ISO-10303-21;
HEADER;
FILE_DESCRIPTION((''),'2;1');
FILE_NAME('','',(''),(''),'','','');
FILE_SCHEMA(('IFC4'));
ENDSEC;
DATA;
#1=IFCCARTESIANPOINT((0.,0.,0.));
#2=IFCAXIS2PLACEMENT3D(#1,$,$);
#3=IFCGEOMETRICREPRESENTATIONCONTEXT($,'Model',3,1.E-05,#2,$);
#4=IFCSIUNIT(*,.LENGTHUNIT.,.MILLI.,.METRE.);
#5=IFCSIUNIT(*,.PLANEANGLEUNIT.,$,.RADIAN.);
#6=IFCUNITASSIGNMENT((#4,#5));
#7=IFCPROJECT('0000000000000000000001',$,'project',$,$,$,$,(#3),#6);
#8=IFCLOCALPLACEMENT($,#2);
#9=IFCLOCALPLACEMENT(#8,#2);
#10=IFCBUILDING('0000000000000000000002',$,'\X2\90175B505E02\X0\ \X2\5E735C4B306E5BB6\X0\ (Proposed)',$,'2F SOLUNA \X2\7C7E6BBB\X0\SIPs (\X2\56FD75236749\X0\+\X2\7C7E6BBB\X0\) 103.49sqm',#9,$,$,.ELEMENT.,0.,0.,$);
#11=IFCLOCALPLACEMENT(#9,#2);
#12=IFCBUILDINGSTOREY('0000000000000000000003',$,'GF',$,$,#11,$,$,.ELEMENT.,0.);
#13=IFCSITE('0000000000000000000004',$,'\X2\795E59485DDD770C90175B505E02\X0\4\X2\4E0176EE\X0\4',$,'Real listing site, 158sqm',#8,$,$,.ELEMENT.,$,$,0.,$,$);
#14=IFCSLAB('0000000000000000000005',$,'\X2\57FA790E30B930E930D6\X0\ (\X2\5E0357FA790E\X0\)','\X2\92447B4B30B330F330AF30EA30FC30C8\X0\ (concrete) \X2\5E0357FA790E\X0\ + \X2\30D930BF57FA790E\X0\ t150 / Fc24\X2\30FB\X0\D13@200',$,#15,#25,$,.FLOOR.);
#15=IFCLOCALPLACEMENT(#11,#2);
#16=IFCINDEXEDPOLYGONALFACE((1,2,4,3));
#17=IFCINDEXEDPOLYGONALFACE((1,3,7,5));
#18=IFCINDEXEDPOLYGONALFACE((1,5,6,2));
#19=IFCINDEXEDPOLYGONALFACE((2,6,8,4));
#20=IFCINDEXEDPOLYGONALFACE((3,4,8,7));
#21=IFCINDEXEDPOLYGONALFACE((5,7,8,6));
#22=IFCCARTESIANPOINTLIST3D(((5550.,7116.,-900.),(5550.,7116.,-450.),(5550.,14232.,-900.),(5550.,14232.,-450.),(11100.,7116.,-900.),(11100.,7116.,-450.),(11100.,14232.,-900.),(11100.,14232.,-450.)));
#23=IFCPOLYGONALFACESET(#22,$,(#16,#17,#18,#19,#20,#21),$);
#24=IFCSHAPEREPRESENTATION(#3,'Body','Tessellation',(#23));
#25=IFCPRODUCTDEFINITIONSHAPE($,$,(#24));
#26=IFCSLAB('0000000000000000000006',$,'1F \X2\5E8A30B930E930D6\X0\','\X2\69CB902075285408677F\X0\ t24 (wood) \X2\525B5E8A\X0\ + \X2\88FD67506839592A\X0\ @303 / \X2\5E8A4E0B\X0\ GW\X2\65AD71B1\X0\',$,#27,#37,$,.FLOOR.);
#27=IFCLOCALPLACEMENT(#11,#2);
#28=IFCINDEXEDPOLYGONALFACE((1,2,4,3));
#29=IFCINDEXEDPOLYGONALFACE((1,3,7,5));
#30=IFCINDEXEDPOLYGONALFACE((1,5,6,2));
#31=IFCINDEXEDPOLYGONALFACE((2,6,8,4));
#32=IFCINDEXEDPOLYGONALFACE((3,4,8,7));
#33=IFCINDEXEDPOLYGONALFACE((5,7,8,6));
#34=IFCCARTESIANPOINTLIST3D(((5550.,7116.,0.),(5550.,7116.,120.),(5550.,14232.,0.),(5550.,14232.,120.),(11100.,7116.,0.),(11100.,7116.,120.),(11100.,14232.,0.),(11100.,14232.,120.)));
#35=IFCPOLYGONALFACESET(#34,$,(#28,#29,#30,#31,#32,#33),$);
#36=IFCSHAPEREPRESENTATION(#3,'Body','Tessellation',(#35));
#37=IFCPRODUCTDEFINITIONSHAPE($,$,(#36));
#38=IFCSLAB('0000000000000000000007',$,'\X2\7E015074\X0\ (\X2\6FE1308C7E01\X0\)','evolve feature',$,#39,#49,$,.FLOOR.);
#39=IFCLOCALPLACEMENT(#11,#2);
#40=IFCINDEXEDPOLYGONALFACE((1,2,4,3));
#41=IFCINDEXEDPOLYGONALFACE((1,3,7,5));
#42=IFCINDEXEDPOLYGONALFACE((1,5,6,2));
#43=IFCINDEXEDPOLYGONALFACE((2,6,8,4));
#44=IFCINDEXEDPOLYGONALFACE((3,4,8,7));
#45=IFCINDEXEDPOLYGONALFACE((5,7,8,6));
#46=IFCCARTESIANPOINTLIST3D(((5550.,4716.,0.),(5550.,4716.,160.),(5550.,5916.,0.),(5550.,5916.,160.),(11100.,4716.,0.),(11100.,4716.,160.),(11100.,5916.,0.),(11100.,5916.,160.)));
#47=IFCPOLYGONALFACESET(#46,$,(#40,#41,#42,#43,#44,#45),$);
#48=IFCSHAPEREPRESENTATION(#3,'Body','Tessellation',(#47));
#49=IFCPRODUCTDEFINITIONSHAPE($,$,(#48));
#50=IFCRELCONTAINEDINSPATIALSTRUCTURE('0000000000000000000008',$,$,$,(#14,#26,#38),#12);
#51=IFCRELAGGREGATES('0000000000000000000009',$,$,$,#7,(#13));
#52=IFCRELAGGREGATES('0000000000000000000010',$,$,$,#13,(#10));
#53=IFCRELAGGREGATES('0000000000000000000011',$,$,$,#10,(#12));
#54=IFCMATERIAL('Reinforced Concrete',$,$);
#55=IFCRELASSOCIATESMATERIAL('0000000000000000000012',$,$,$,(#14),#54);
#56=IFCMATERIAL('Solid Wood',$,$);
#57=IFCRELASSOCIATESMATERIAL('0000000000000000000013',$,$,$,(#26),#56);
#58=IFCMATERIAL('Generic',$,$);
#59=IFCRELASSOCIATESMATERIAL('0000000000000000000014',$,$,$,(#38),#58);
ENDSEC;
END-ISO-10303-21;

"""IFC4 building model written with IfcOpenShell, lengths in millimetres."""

from ifc_helpers import new_model, si_unit, frame, frame_2d, origin, place, context, project, spatial, rectangle, extrude, material, element, save


model = new_model("IFC4")

# Units and contexts
model_context = context("Model", 3, precision=1e-05, world=origin())
ifc_project = project(units=[si_unit("LENGTHUNIT", "METRE", prefix="MILLI"), si_unit("PLANEANGLEUNIT", "RADIAN")], contexts=[model_context])

# Site, building, storey
site_placement = place(None, origin())
site = spatial("IfcSite", under=ifc_project, at=site_placement, Name="神奈川県逗子市4丁目4", ObjectType="Real listing site, 158sqm", CompositionType="ELEMENT", RefElevation=0.0)
building_placement = place(site_placement, origin())
building = spatial("IfcBuilding", under=site, at=building_placement, Name="逗子市 平屋の家 (Proposed)", ObjectType="2F SOLUNA 籾殻SIPs (国産杉+籾殻) 103.49sqm", CompositionType="ELEMENT", ElevationOfRefHeight=0.0, ElevationOfTerrain=0.0)
storey_placement = place(building_placement, origin())
storey = spatial("IfcBuildingStorey", under=building, at=storey_placement, Name="GF", CompositionType="ELEMENT", Elevation=0.0)

# Slabs
ifc_material_1 = material(Name="Reinforced Concrete")
slab_1_placement = place(storey_placement, frame((2775.0, 3558.0, -450.0)))
element("IfcSlab", 1, at=slab_1_placement, inside=storey, material=ifc_material_1, Name="基礎スラブ (布基礎)", Description="鉄筋コンクリート (concrete) 布基礎 + ベタ基礎 t150 / Fc24・D13@200", PredefinedType="FLOOR", context=model_context, shape_type="SweptSolid", body=[
    extrude(rectangle(XDim=5550.0, YDim=7116.0, at=frame_2d((2775.0, 3558.0))), frame((2775.0, 3558.0, -450.0)), (0.0, 0.0, 1.0), 450.0),
])
ifc_material_2 = material(Name="Solid Wood")
slab_2_placement = place(storey_placement, frame((2775.0, 3558.0, 0.0)))
element("IfcSlab", 2, at=slab_2_placement, inside=storey, material=ifc_material_2, Name="1F 床スラブ", Description="構造用合板 t24 (wood) 剛床 + 製材根太 @303 / 床下 GW断熱", PredefinedType="FLOOR", context=model_context, shape_type="SweptSolid", body=[
    extrude(rectangle(XDim=5550.0, YDim=7116.0, at=frame_2d((2775.0, 3558.0))), frame((2775.0, 3558.0, 0.0)), (0.0, 0.0, 1.0), 120.0),
])
ifc_material_3 = material(Name="Generic")
slab_3_placement = place(storey_placement, frame((2775.0, 2358.0, 0.0)))
element("IfcSlab", 3, at=slab_3_placement, inside=storey, material=ifc_material_3, Name="縁側 (濡れ縁)", Description="evolve feature", PredefinedType="FLOOR", context=model_context, shape_type="SweptSolid", body=[
    extrude(rectangle(XDim=5550.0, YDim=1200.0, at=frame_2d((2775.0, 600.0))), frame((2775.0, 2358.0, 0.0)), (0.0, 0.0, 1.0), 160.0),
])

save(model, "model.ifc")
